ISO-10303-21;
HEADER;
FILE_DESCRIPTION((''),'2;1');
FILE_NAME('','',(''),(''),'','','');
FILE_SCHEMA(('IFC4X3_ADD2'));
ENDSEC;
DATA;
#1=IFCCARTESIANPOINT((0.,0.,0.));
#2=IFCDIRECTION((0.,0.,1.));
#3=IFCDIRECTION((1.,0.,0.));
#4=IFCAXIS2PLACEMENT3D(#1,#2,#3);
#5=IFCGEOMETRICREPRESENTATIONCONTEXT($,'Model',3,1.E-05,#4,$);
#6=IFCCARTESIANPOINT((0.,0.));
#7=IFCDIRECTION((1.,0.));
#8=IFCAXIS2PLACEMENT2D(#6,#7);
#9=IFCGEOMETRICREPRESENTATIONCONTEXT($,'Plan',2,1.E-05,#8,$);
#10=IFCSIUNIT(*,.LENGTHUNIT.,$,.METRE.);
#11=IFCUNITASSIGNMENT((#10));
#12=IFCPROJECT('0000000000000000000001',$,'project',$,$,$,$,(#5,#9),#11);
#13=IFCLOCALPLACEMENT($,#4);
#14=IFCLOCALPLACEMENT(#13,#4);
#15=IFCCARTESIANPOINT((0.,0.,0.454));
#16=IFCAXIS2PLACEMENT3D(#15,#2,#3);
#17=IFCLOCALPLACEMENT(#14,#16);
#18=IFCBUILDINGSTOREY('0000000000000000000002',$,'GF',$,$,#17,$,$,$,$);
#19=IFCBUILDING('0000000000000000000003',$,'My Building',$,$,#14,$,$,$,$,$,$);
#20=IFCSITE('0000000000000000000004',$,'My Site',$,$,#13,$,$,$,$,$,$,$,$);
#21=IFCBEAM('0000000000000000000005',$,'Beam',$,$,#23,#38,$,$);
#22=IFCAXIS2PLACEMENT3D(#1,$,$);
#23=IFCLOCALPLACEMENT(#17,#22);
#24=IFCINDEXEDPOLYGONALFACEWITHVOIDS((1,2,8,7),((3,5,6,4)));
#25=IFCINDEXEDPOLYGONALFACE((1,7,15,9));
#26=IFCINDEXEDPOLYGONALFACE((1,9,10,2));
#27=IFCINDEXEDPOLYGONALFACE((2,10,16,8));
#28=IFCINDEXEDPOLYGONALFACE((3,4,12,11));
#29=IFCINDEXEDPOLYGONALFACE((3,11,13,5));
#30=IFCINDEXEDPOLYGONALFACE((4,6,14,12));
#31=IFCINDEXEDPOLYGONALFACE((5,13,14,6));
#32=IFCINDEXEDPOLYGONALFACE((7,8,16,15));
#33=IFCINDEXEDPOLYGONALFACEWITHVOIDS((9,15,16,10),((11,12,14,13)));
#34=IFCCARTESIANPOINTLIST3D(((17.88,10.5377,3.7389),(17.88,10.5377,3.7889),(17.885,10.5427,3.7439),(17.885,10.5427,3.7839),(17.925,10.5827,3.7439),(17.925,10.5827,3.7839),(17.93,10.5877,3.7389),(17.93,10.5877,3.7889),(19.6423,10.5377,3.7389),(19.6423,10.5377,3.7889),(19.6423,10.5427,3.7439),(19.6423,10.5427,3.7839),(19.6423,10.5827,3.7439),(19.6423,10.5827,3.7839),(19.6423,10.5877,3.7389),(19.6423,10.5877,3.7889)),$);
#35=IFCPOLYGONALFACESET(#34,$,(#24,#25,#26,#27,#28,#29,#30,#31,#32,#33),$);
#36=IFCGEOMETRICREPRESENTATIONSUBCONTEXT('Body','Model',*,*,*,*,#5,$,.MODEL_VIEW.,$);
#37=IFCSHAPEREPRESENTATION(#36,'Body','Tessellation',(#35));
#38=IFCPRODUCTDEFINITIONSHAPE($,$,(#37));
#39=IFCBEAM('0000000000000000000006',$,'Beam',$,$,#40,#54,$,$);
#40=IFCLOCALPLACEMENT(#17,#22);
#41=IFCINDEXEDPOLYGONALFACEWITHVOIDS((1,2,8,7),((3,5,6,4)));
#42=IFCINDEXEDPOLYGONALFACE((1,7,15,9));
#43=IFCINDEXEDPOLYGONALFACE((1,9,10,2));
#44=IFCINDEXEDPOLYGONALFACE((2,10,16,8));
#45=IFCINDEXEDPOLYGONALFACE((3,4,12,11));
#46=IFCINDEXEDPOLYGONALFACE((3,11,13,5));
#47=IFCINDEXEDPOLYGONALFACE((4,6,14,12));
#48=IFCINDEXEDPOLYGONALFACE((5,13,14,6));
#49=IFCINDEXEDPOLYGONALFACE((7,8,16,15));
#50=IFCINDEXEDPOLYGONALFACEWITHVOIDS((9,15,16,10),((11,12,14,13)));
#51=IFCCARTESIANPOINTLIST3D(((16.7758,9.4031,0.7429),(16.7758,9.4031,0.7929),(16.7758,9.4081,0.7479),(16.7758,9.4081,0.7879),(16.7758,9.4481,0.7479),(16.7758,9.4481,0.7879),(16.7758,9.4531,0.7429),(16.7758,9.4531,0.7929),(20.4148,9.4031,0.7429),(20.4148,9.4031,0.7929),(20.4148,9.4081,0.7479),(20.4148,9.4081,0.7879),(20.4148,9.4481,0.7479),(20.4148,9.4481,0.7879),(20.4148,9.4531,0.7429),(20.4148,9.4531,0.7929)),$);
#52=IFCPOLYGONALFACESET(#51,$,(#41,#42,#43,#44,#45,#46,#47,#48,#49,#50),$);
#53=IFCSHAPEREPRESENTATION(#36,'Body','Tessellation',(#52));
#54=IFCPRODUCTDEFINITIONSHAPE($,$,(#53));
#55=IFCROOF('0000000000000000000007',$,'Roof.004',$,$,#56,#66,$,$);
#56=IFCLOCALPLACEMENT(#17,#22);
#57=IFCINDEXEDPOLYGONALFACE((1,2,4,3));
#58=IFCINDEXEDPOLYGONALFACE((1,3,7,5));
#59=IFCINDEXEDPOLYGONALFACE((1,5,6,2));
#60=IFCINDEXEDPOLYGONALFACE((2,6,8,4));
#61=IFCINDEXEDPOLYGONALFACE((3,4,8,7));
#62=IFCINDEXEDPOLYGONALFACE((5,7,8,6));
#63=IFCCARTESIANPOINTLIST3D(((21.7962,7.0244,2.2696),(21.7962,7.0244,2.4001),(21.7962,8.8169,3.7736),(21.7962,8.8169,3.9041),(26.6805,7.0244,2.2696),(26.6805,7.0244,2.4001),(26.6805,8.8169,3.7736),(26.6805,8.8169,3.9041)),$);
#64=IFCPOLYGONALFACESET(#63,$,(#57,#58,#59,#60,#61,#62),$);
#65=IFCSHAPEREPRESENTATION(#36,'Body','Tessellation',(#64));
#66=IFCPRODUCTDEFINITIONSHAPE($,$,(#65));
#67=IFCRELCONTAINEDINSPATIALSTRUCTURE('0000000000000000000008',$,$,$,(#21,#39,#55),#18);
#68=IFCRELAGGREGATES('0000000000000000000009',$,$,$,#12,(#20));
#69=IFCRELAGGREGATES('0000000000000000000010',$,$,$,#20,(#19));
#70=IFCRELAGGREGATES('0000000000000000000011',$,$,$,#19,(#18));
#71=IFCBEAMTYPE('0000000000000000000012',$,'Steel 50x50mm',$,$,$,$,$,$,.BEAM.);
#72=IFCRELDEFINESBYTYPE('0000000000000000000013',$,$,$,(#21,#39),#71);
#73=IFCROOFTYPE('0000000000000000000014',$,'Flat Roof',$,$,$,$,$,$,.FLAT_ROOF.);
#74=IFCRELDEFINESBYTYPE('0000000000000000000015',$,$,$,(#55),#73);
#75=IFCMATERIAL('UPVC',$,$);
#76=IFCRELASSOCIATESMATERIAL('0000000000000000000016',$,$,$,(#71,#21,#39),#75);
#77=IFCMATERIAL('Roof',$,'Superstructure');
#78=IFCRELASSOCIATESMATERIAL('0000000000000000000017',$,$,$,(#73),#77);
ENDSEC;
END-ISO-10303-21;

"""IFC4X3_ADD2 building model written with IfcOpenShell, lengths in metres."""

from ifc_helpers import new_model, si_unit, frame, origin_with_axes, origin_2d_with_axis, place, context, subcontext, project, spatial, polyline, hollow_rectangle, outline, extrude, clip, halfspace, material, material_profile, profile_set, profile_usage, type_object, element, save


model = new_model("IFC4X3_ADD2")

# Units and contexts
model_context = context("Model", 3, precision=1e-05, world=origin_with_axes())
plan_context = context("Plan", 2, precision=1e-05, world=origin_2d_with_axis())
body_context = subcontext(model_context, "Body", "Model", "MODEL_VIEW")
ifc_project = project(units=[si_unit("LENGTHUNIT", "METRE")], contexts=[model_context, plan_context])

# Site, building, storey
site_placement = place(None, origin_with_axes())
site = spatial("IfcSite", under=ifc_project, at=site_placement, Name="My Site")
building_placement = place(site_placement, origin_with_axes())
building = spatial("IfcBuilding", under=site, at=building_placement, Name="My Building")
storey_placement = place(building_placement, frame((0.0, 0.0, 0.454), z_axis=(0.0, 0.0, 1.0), x_axis=(1.0, 0.0, 0.0)))
storey = spatial("IfcBuildingStorey", under=building, at=storey_placement, Name="GF")

# Shared definitions
ifc_material_1 = material(Name="UPVC")

# Beams
ifc_material_profile_1 = material_profile(ifc_material_1, hollow_rectangle(XDim=0.05, YDim=0.05, WallThickness=0.005))
ifc_profile_set_1 = profile_set([ifc_material_profile_1])
ifc_profile_usage_1 = profile_usage(ifc_profile_set_1)
beam_type_1 = type_object("IfcBeamType", Name="Steel 50x50mm", PredefinedType="BEAM", material=ifc_profile_set_1)
beam_1_placement = place(storey_placement, frame((17.88, 10.5627, 3.7639), z_axis=(1.0, 0.0, 0.0), x_axis=(0.0, 1.0, 0.0)))
element("IfcBeam", 1, at=beam_1_placement, inside=storey, type_object=beam_type_1, material=ifc_profile_usage_1, Name="Beam", context=body_context, shape_type="Clipping", body=[
    clip(extrude(hollow_rectangle(XDim=0.05, YDim=0.05, WallThickness=0.005), origin_with_axes(), (0.0, 0.0, 1.0), 1.7622), halfspace(frame((-0.025, -4.2179, 0.0), z_axis=(0.707107, 0.0, -0.707107), x_axis=(0.0, -1.0, 0.0)), False)),
])
ifc_profile_usage_2 = profile_usage(ifc_profile_set_1)
beam_2_placement = place(storey_placement, frame((16.7758, 9.4281, 0.7679), z_axis=(1.0, 0.0, 0.0), x_axis=(0.0, 1.0, 0.0)))
element("IfcBeam", 2, at=beam_2_placement, inside=storey, type_object=beam_type_1, material=ifc_profile_usage_2, Name="Beam", context=body_context, shape_type="SweptSolid", body=[
    extrude(hollow_rectangle(XDim=0.05, YDim=0.05, WallThickness=0.005), origin_with_axes(), (0.0, 0.0, 1.0), 3.6389),
])

# Roof
ifc_material_2 = material(Name="Roof", Category="Superstructure")
roof_type = type_object("IfcRoofType", Name="Flat Roof", PredefinedType="FLAT_ROOF", material=ifc_material_2)
roof_placement = place(storey_placement, frame((21.7962, 8.0241, 3.1084), z_axis=(0.0, -0.642788, 0.766044), x_axis=(1.0, 0.0, 0.0)))
element("IfcRoof", 3, at=roof_placement, inside=storey, type_object=roof_type, Name="Roof.004", context=body_context, shape_type="SweptSolid", body=[
    extrude(outline(polyline([(-2.4421, -0.0653), (2.4421, -0.0653), (2.4421, 0.0653), (-2.4421, 0.0653), (-2.4421, -0.0653)])), frame((2.4421, 1.0768, 0.05), z_axis=(0.0, 0.766044, -0.642788), x_axis=(1.0, 0.0, 0.0)), (0.0, 0.642788, -0.766044), 2.3398),
])

save(model, "model.ifc")
